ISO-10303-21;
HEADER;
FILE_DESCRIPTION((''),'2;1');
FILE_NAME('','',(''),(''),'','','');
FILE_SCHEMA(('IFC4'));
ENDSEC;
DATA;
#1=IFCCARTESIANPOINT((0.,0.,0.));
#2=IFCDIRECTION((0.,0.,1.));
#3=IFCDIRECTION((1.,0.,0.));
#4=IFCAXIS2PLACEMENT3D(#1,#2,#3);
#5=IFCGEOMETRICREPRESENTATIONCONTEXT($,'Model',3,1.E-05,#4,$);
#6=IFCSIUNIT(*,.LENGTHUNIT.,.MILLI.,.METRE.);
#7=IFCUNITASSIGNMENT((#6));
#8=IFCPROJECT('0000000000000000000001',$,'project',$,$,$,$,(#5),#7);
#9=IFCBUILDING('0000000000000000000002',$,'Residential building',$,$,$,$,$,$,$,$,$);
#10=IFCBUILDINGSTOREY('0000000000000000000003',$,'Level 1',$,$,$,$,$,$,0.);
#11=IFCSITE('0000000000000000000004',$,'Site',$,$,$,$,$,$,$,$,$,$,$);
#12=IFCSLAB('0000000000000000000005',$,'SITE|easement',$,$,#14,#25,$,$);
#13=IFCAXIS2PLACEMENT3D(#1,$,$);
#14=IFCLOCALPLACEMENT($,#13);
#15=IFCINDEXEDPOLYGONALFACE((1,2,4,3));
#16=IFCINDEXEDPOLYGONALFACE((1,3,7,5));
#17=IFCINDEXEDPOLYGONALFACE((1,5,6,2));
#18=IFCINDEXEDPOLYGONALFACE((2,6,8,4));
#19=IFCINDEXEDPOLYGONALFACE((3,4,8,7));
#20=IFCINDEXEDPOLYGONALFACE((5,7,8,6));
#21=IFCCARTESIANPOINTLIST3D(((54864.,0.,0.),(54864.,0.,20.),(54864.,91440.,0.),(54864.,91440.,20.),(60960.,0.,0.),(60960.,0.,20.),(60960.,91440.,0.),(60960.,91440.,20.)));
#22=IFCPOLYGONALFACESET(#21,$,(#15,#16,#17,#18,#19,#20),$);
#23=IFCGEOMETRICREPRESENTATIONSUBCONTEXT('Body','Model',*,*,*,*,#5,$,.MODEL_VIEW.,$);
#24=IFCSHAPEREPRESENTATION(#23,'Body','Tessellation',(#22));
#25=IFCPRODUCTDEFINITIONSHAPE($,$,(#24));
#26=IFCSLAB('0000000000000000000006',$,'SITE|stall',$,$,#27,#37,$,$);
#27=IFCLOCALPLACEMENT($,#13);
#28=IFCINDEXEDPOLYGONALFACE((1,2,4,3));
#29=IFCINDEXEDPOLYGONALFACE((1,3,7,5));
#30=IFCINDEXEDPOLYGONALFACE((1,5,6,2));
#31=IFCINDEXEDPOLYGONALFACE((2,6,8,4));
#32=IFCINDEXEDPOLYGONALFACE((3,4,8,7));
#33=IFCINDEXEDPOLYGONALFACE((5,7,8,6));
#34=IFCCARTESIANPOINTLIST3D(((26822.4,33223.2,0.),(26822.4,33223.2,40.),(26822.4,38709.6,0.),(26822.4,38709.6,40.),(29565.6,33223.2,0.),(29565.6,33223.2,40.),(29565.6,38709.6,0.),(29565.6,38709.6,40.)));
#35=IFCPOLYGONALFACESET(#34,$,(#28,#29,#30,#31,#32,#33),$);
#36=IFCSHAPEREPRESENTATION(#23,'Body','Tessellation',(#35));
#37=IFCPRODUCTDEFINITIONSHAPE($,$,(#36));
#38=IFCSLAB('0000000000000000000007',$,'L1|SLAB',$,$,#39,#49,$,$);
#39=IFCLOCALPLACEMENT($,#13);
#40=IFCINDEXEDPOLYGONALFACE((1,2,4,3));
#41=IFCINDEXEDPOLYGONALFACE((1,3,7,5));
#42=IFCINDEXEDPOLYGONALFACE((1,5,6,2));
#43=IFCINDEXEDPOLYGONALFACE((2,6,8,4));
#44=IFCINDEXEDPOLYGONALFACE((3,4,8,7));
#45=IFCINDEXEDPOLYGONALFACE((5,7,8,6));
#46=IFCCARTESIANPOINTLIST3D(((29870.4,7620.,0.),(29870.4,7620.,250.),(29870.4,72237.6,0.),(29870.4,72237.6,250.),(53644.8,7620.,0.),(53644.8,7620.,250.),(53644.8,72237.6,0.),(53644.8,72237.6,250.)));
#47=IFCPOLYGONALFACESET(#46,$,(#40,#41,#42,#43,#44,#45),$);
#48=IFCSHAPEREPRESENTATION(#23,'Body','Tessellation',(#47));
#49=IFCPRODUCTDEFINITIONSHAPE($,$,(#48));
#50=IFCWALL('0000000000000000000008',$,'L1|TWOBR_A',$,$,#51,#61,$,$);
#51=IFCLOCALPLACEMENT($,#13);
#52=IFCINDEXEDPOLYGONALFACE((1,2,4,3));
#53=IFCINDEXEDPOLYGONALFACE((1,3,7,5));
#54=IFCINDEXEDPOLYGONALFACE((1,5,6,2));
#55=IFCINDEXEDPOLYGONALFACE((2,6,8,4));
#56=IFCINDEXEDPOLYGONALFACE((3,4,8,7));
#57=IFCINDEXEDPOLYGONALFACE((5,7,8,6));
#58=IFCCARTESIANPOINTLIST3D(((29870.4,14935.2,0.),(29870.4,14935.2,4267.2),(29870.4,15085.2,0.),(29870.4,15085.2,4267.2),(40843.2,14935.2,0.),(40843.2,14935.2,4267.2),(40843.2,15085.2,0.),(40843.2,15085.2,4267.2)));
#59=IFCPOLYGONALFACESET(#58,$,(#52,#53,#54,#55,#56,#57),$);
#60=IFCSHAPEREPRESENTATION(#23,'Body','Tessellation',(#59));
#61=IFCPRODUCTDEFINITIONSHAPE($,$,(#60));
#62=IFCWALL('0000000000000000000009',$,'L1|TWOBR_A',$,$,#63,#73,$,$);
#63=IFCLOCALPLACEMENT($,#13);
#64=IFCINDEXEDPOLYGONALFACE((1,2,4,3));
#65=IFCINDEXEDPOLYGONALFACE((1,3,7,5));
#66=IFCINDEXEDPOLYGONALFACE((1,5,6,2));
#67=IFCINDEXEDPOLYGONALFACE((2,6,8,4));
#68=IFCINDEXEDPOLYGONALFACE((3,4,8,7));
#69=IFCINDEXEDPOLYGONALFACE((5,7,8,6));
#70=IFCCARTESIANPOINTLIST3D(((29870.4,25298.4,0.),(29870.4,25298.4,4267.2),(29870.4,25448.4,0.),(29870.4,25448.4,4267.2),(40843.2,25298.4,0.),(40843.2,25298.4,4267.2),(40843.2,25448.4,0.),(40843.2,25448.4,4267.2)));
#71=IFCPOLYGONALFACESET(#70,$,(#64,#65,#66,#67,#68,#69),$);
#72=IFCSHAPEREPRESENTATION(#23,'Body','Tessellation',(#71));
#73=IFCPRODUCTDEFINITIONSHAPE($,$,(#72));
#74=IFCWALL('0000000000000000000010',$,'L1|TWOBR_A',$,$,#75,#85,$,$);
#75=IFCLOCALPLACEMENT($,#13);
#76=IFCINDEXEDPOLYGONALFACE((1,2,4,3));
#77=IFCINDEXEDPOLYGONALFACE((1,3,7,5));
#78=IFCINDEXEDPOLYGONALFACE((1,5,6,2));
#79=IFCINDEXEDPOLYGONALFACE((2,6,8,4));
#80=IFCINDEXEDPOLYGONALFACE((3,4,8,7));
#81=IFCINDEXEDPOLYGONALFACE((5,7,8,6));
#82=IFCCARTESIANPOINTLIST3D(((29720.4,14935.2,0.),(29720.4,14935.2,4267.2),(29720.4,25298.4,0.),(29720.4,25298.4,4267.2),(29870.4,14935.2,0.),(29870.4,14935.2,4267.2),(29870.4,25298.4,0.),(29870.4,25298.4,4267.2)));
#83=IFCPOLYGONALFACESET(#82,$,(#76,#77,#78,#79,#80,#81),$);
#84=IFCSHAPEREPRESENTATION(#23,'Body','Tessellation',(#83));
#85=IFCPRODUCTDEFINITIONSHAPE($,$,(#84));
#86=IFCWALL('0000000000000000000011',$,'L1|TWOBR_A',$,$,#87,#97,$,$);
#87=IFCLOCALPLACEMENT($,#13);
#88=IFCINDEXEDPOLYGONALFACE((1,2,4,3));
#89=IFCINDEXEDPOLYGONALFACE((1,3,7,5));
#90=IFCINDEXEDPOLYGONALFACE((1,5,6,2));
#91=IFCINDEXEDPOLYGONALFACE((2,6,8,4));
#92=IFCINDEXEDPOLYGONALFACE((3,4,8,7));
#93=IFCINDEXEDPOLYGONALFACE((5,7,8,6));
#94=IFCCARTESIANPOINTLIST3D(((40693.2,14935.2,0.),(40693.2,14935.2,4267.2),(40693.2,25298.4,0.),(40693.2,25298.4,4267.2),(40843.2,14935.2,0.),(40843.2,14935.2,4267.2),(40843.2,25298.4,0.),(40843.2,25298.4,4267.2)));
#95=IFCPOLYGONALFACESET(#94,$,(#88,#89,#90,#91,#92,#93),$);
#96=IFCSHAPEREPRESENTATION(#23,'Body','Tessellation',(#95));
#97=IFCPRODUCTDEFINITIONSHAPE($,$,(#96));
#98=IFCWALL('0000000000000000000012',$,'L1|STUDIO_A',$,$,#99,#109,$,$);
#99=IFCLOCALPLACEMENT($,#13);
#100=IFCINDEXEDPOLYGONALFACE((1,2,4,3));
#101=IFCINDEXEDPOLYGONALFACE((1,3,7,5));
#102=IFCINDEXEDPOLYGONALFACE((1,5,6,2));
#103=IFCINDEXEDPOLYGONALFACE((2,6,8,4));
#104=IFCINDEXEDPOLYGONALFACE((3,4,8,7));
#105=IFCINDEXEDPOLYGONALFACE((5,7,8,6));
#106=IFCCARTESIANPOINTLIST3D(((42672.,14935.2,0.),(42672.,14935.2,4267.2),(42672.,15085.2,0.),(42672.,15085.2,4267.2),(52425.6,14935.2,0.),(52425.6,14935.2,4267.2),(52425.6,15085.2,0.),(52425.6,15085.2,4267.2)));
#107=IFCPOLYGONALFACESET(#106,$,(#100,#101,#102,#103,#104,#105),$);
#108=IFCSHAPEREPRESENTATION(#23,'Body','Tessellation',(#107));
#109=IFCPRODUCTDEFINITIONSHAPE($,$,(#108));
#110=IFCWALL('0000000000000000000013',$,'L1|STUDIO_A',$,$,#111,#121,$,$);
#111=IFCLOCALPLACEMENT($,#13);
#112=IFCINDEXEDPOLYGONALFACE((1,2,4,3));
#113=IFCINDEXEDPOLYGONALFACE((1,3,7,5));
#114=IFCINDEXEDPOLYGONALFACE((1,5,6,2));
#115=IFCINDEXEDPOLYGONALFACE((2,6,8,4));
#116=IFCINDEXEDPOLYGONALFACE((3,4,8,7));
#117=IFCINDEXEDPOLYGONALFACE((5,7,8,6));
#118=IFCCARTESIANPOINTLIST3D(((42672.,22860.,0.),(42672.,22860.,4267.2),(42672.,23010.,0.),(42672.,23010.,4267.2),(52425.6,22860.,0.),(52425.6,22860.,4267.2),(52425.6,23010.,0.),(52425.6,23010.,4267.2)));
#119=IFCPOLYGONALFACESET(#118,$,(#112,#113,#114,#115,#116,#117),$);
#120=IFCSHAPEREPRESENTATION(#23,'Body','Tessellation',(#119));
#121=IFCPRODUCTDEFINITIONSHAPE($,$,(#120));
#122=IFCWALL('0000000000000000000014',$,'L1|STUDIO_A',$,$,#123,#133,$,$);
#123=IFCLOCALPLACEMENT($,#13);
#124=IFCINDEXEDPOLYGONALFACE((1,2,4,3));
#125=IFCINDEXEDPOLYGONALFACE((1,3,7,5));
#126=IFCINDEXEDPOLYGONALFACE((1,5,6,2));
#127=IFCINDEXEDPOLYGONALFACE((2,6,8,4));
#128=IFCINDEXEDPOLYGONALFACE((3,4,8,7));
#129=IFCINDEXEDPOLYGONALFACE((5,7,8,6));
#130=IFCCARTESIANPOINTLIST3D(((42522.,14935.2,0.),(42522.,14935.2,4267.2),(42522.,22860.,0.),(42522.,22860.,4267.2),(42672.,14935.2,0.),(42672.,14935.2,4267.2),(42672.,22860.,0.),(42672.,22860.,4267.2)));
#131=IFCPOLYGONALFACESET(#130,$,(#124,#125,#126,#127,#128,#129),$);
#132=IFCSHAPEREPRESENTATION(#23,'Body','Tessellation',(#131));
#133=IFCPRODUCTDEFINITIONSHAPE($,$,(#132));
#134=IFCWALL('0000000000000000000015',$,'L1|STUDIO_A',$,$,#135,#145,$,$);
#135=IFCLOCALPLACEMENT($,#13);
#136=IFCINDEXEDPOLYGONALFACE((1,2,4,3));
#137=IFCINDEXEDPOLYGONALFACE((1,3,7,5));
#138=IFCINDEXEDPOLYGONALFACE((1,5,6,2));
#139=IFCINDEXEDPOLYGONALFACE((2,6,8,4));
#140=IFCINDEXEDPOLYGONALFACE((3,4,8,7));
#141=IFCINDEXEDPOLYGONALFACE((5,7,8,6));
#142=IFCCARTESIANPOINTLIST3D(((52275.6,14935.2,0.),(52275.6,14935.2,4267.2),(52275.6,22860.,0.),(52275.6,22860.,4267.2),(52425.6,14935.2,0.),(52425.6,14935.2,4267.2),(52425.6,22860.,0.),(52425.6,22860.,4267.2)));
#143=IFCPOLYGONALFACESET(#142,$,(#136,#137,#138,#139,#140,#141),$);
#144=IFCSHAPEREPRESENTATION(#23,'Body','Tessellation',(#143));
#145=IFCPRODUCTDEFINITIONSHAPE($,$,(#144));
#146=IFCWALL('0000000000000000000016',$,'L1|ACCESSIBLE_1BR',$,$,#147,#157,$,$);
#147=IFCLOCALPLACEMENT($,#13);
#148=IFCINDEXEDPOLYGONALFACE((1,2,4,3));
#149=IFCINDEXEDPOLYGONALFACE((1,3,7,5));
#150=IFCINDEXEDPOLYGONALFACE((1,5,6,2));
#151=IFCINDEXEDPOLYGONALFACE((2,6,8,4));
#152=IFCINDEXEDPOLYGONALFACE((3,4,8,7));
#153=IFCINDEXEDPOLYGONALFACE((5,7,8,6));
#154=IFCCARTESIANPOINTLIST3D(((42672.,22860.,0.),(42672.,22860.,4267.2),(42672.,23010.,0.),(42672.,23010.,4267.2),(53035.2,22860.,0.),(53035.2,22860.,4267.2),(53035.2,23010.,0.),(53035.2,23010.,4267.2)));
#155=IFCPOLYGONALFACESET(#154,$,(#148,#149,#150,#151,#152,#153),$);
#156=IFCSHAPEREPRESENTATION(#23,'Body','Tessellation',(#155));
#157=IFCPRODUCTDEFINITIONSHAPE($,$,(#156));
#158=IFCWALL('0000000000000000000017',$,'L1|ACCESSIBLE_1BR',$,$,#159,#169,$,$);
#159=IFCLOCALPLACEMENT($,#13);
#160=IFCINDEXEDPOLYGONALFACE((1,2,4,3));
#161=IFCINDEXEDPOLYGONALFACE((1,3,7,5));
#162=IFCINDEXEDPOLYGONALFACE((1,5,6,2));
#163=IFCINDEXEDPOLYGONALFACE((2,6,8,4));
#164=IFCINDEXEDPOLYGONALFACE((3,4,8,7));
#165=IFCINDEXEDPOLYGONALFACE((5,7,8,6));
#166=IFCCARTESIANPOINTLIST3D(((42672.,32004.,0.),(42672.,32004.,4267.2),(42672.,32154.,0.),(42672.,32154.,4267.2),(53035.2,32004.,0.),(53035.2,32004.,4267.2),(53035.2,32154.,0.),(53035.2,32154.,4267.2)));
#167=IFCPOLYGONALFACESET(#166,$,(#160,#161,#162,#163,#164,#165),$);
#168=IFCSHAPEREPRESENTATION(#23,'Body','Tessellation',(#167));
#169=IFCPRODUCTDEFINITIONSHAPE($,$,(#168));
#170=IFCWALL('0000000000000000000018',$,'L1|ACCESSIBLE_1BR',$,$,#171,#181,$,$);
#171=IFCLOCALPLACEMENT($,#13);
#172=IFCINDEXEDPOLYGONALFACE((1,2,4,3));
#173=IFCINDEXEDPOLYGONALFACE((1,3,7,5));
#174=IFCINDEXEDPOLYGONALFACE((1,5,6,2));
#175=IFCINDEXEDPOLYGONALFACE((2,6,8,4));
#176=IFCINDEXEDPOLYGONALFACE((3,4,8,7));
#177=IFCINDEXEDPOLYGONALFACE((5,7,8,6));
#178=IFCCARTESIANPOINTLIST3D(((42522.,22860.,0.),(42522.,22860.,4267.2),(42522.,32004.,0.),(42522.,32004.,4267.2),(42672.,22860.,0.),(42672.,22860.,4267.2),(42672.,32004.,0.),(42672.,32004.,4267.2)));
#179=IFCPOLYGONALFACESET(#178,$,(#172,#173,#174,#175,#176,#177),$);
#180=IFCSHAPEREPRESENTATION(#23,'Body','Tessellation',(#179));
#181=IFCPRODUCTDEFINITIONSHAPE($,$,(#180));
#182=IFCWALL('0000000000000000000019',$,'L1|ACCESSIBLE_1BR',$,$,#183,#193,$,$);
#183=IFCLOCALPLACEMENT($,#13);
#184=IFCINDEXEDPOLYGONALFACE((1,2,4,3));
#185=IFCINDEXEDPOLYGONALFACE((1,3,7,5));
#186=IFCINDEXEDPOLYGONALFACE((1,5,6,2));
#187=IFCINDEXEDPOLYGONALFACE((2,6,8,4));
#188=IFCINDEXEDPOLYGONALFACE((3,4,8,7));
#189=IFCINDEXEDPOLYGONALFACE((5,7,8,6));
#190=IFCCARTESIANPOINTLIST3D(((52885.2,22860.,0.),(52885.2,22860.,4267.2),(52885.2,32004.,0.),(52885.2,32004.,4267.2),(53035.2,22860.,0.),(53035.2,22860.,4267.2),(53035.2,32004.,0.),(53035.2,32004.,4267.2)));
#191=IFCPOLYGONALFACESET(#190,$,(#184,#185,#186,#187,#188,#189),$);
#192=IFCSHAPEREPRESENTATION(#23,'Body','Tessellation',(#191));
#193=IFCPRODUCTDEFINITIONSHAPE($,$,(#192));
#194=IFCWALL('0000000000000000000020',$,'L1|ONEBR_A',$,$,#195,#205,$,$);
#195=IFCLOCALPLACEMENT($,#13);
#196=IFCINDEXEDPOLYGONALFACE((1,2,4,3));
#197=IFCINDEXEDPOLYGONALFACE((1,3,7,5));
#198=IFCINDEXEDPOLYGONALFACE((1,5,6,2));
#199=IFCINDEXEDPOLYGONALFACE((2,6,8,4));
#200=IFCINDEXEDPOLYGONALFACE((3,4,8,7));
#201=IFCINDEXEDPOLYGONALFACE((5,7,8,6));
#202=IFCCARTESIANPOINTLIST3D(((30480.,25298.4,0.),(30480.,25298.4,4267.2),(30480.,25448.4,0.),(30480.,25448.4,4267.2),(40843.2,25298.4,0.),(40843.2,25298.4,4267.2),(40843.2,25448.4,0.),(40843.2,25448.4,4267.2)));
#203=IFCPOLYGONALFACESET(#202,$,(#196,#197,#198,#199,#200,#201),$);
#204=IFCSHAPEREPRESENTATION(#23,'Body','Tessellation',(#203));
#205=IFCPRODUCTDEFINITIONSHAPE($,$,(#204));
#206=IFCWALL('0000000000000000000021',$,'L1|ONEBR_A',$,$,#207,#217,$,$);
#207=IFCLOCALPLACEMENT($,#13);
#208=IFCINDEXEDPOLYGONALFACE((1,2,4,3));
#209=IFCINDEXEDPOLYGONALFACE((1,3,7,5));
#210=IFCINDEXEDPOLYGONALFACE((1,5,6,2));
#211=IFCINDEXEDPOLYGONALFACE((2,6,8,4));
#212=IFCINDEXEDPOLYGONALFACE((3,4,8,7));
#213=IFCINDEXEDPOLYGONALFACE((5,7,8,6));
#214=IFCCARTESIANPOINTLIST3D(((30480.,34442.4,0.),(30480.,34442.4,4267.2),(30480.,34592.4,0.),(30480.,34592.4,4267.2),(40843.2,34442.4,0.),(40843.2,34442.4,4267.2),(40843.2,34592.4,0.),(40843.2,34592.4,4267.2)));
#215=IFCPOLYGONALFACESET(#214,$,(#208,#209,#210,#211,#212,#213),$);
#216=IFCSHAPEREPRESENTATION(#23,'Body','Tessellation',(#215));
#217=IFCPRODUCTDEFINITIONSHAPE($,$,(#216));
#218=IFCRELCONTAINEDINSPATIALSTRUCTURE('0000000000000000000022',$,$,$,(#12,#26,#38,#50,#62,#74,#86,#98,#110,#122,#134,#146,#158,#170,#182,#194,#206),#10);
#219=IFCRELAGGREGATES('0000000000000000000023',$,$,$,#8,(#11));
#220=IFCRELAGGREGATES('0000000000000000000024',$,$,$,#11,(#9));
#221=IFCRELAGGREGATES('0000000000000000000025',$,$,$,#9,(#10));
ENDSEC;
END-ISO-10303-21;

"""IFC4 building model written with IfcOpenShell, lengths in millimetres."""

from ifc_helpers import new_model, si_unit, frame, origin_with_axes, place, context, subcontext, project, spatial, indexed_curve, outline, extrude, element, save


model = new_model("IFC4")

# Units and contexts
model_context = context("Model", 3, precision=1e-05, world=origin_with_axes())
body_context = subcontext(model_context, "Body", "Model", "MODEL_VIEW")
ifc_project = project(units=[si_unit("LENGTHUNIT", "METRE", prefix="MILLI")], contexts=[model_context])

# Site, building, storey
site = spatial("IfcSite", under=ifc_project, Name="Site")
building = spatial("IfcBuilding", under=site, Name="Residential building")
storey = spatial("IfcBuildingStorey", under=building, Name="Level 1", Elevation=0.0)

# Slabs
slab_1_placement = place(None, frame((54864.0, 0.0, 0.0), z_axis=(0.0, 0.0, 1.0), x_axis=(1.0, 0.0, 0.0)))
element("IfcSlab", 1, at=slab_1_placement, inside=storey, Name="SITE|easement", context=body_context, shape_type="SweptSolid", body=[
    extrude(outline(indexed_curve([(0.0, 0.0), (6096.0, 0.0), (6096.0, 91440.0), (0.0, 91440.0), (0.0, 0.0)])), None, (0.0, 0.0, 1.0), 20.0),
])
slab_2_placement = place(None, frame((26822.4, 33223.2, 0.0), z_axis=(0.0, 0.0, 1.0), x_axis=(1.0, 0.0, 0.0)))
element("IfcSlab", 2, at=slab_2_placement, inside=storey, Name="SITE|stall", context=body_context, shape_type="SweptSolid", body=[
    extrude(outline(indexed_curve([(0.0, 0.0), (2743.2, 0.0), (2743.2, 5486.4), (0.0, 5486.4), (0.0, 0.0)])), None, (0.0, 0.0, 1.0), 40.0),
])
slab_3_placement = place(None, frame((29870.4, 7620.0, 0.0), z_axis=(0.0, 0.0, 1.0), x_axis=(1.0, 0.0, 0.0)))
element("IfcSlab", 3, at=slab_3_placement, inside=storey, Name="L1|SLAB", context=body_context, shape_type="SweptSolid", body=[
    extrude(outline(indexed_curve([(0.0, 0.0), (23774.4, 0.0), (23774.4, 64617.6), (0.0, 64617.6), (0.0, 0.0)])), None, (0.0, 0.0, 1.0), 250.0),
])

# Walls
for number, where, z_axis, x_axis, name in (
    (4, (29870.4, 14935.2, 0.0), (0.0, 0.0, 1.0), (1.0, 0.0, 0.0), "L1|TWOBR_A"),
    (5, (29870.4, 25298.4, 0.0), (0.0, 0.0, 1.0), (1.0, 0.0, 0.0), "L1|TWOBR_A"),
):
    element("IfcWall", number, at=place(None, frame(where, z_axis=z_axis, x_axis=x_axis)), inside=storey, Name=name, context=body_context, shape_type="SweptSolid", body=[
        extrude(outline(indexed_curve([(0.0, 0.0), (0.0, 150.0), (10972.8, 150.0), (10972.8, 0.0), (0.0, 0.0)], self_intersect=False)), origin_with_axes(), (0.0, 0.0, 1.0), 4267.2),
    ])
for number, where, z_axis, x_axis, name in (
    (6, (29870.4, 14935.2, 0.0), (0.0, 0.0, 1.0), (0.0, 1.0, 0.0), "L1|TWOBR_A"),
    (7, (40843.2, 14935.2, 0.0), (0.0, 0.0, 1.0), (0.0, 1.0, 0.0), "L1|TWOBR_A"),
):
    element("IfcWall", number, at=place(None, frame(where, z_axis=z_axis, x_axis=x_axis)), inside=storey, Name=name, context=body_context, shape_type="SweptSolid", body=[
        extrude(outline(indexed_curve([(0.0, 0.0), (0.0, 150.0), (10363.2, 150.0), (10363.2, 0.0), (0.0, 0.0)], self_intersect=False)), origin_with_axes(), (0.0, 0.0, 1.0), 4267.2),
    ])
for number, where, z_axis, x_axis, name in (
    (8, (42672.0, 14935.2, 0.0), (0.0, 0.0, 1.0), (1.0, 0.0, 0.0), "L1|STUDIO_A"),
    (9, (42672.0, 22860.0, 0.0), (0.0, 0.0, 1.0), (1.0, 0.0, 0.0), "L1|STUDIO_A"),
):
    element("IfcWall", number, at=place(None, frame(where, z_axis=z_axis, x_axis=x_axis)), inside=storey, Name=name, context=body_context, shape_type="SweptSolid", body=[
        extrude(outline(indexed_curve([(0.0, 0.0), (0.0, 150.0), (9753.6, 150.0), (9753.6, 0.0), (0.0, 0.0)], self_intersect=False)), origin_with_axes(), (0.0, 0.0, 1.0), 4267.2),
    ])
for number, where, z_axis, x_axis, name in (
    (10, (42672.0, 14935.2, 0.0), (0.0, 0.0, 1.0), (0.0, 1.0, 0.0), "L1|STUDIO_A"),
    (11, (52425.6, 14935.2, 0.0), (0.0, 0.0, 1.0), (0.0, 1.0, 0.0), "L1|STUDIO_A"),
):
    element("IfcWall", number, at=place(None, frame(where, z_axis=z_axis, x_axis=x_axis)), inside=storey, Name=name, context=body_context, shape_type="SweptSolid", body=[
        extrude(outline(indexed_curve([(0.0, 0.0), (0.0, 150.0), (7924.8, 150.0), (7924.8, 0.0), (0.0, 0.0)], self_intersect=False)), origin_with_axes(), (0.0, 0.0, 1.0), 4267.2),
    ])
for number, where, z_axis, x_axis, name in (
    (12, (42672.0, 22860.0, 0.0), (0.0, 0.0, 1.0), (1.0, 0.0, 0.0), "L1|ACCESSIBLE_1BR"),
    (13, (42672.0, 32004.0, 0.0), (0.0, 0.0, 1.0), (1.0, 0.0, 0.0), "L1|ACCESSIBLE_1BR"),
):
    element("IfcWall", number, at=place(None, frame(where, z_axis=z_axis, x_axis=x_axis)), inside=storey, Name=name, context=body_context, shape_type="SweptSolid", body=[
        extrude(outline(indexed_curve([(0.0, 0.0), (0.0, 150.0), (10363.2, 150.0), (10363.2, 0.0), (0.0, 0.0)], self_intersect=False)), origin_with_axes(), (0.0, 0.0, 1.0), 4267.2),
    ])
for number, where, z_axis, x_axis, name in (
    (14, (42672.0, 22860.0, 0.0), (0.0, 0.0, 1.0), (0.0, 1.0, 0.0), "L1|ACCESSIBLE_1BR"),
    (15, (53035.2, 22860.0, 0.0), (0.0, 0.0, 1.0), (0.0, 1.0, 0.0), "L1|ACCESSIBLE_1BR"),
):
    element("IfcWall", number, at=place(None, frame(where, z_axis=z_axis, x_axis=x_axis)), inside=storey, Name=name, context=body_context, shape_type="SweptSolid", body=[
        extrude(outline(indexed_curve([(0.0, 0.0), (0.0, 150.0), (9144.0, 150.0), (9144.0, 0.0), (0.0, 0.0)], self_intersect=False)), origin_with_axes(), (0.0, 0.0, 1.0), 4267.2),
    ])
for number, where, z_axis, x_axis, name in (
    (16, (30480.0, 25298.4, 0.0), (0.0, 0.0, 1.0), (1.0, 0.0, 0.0), "L1|ONEBR_A"),
    (17, (30480.0, 34442.4, 0.0), (0.0, 0.0, 1.0), (1.0, 0.0, 0.0), "L1|ONEBR_A"),
):
    element("IfcWall", number, at=place(None, frame(where, z_axis=z_axis, x_axis=x_axis)), inside=storey, Name=name, context=body_context, shape_type="SweptSolid", body=[
        extrude(outline(indexed_curve([(0.0, 0.0), (0.0, 150.0), (10363.2, 150.0), (10363.2, 0.0), (0.0, 0.0)], self_intersect=False)), origin_with_axes(), (0.0, 0.0, 1.0), 4267.2),
    ])

save(model, "model.ifc")
